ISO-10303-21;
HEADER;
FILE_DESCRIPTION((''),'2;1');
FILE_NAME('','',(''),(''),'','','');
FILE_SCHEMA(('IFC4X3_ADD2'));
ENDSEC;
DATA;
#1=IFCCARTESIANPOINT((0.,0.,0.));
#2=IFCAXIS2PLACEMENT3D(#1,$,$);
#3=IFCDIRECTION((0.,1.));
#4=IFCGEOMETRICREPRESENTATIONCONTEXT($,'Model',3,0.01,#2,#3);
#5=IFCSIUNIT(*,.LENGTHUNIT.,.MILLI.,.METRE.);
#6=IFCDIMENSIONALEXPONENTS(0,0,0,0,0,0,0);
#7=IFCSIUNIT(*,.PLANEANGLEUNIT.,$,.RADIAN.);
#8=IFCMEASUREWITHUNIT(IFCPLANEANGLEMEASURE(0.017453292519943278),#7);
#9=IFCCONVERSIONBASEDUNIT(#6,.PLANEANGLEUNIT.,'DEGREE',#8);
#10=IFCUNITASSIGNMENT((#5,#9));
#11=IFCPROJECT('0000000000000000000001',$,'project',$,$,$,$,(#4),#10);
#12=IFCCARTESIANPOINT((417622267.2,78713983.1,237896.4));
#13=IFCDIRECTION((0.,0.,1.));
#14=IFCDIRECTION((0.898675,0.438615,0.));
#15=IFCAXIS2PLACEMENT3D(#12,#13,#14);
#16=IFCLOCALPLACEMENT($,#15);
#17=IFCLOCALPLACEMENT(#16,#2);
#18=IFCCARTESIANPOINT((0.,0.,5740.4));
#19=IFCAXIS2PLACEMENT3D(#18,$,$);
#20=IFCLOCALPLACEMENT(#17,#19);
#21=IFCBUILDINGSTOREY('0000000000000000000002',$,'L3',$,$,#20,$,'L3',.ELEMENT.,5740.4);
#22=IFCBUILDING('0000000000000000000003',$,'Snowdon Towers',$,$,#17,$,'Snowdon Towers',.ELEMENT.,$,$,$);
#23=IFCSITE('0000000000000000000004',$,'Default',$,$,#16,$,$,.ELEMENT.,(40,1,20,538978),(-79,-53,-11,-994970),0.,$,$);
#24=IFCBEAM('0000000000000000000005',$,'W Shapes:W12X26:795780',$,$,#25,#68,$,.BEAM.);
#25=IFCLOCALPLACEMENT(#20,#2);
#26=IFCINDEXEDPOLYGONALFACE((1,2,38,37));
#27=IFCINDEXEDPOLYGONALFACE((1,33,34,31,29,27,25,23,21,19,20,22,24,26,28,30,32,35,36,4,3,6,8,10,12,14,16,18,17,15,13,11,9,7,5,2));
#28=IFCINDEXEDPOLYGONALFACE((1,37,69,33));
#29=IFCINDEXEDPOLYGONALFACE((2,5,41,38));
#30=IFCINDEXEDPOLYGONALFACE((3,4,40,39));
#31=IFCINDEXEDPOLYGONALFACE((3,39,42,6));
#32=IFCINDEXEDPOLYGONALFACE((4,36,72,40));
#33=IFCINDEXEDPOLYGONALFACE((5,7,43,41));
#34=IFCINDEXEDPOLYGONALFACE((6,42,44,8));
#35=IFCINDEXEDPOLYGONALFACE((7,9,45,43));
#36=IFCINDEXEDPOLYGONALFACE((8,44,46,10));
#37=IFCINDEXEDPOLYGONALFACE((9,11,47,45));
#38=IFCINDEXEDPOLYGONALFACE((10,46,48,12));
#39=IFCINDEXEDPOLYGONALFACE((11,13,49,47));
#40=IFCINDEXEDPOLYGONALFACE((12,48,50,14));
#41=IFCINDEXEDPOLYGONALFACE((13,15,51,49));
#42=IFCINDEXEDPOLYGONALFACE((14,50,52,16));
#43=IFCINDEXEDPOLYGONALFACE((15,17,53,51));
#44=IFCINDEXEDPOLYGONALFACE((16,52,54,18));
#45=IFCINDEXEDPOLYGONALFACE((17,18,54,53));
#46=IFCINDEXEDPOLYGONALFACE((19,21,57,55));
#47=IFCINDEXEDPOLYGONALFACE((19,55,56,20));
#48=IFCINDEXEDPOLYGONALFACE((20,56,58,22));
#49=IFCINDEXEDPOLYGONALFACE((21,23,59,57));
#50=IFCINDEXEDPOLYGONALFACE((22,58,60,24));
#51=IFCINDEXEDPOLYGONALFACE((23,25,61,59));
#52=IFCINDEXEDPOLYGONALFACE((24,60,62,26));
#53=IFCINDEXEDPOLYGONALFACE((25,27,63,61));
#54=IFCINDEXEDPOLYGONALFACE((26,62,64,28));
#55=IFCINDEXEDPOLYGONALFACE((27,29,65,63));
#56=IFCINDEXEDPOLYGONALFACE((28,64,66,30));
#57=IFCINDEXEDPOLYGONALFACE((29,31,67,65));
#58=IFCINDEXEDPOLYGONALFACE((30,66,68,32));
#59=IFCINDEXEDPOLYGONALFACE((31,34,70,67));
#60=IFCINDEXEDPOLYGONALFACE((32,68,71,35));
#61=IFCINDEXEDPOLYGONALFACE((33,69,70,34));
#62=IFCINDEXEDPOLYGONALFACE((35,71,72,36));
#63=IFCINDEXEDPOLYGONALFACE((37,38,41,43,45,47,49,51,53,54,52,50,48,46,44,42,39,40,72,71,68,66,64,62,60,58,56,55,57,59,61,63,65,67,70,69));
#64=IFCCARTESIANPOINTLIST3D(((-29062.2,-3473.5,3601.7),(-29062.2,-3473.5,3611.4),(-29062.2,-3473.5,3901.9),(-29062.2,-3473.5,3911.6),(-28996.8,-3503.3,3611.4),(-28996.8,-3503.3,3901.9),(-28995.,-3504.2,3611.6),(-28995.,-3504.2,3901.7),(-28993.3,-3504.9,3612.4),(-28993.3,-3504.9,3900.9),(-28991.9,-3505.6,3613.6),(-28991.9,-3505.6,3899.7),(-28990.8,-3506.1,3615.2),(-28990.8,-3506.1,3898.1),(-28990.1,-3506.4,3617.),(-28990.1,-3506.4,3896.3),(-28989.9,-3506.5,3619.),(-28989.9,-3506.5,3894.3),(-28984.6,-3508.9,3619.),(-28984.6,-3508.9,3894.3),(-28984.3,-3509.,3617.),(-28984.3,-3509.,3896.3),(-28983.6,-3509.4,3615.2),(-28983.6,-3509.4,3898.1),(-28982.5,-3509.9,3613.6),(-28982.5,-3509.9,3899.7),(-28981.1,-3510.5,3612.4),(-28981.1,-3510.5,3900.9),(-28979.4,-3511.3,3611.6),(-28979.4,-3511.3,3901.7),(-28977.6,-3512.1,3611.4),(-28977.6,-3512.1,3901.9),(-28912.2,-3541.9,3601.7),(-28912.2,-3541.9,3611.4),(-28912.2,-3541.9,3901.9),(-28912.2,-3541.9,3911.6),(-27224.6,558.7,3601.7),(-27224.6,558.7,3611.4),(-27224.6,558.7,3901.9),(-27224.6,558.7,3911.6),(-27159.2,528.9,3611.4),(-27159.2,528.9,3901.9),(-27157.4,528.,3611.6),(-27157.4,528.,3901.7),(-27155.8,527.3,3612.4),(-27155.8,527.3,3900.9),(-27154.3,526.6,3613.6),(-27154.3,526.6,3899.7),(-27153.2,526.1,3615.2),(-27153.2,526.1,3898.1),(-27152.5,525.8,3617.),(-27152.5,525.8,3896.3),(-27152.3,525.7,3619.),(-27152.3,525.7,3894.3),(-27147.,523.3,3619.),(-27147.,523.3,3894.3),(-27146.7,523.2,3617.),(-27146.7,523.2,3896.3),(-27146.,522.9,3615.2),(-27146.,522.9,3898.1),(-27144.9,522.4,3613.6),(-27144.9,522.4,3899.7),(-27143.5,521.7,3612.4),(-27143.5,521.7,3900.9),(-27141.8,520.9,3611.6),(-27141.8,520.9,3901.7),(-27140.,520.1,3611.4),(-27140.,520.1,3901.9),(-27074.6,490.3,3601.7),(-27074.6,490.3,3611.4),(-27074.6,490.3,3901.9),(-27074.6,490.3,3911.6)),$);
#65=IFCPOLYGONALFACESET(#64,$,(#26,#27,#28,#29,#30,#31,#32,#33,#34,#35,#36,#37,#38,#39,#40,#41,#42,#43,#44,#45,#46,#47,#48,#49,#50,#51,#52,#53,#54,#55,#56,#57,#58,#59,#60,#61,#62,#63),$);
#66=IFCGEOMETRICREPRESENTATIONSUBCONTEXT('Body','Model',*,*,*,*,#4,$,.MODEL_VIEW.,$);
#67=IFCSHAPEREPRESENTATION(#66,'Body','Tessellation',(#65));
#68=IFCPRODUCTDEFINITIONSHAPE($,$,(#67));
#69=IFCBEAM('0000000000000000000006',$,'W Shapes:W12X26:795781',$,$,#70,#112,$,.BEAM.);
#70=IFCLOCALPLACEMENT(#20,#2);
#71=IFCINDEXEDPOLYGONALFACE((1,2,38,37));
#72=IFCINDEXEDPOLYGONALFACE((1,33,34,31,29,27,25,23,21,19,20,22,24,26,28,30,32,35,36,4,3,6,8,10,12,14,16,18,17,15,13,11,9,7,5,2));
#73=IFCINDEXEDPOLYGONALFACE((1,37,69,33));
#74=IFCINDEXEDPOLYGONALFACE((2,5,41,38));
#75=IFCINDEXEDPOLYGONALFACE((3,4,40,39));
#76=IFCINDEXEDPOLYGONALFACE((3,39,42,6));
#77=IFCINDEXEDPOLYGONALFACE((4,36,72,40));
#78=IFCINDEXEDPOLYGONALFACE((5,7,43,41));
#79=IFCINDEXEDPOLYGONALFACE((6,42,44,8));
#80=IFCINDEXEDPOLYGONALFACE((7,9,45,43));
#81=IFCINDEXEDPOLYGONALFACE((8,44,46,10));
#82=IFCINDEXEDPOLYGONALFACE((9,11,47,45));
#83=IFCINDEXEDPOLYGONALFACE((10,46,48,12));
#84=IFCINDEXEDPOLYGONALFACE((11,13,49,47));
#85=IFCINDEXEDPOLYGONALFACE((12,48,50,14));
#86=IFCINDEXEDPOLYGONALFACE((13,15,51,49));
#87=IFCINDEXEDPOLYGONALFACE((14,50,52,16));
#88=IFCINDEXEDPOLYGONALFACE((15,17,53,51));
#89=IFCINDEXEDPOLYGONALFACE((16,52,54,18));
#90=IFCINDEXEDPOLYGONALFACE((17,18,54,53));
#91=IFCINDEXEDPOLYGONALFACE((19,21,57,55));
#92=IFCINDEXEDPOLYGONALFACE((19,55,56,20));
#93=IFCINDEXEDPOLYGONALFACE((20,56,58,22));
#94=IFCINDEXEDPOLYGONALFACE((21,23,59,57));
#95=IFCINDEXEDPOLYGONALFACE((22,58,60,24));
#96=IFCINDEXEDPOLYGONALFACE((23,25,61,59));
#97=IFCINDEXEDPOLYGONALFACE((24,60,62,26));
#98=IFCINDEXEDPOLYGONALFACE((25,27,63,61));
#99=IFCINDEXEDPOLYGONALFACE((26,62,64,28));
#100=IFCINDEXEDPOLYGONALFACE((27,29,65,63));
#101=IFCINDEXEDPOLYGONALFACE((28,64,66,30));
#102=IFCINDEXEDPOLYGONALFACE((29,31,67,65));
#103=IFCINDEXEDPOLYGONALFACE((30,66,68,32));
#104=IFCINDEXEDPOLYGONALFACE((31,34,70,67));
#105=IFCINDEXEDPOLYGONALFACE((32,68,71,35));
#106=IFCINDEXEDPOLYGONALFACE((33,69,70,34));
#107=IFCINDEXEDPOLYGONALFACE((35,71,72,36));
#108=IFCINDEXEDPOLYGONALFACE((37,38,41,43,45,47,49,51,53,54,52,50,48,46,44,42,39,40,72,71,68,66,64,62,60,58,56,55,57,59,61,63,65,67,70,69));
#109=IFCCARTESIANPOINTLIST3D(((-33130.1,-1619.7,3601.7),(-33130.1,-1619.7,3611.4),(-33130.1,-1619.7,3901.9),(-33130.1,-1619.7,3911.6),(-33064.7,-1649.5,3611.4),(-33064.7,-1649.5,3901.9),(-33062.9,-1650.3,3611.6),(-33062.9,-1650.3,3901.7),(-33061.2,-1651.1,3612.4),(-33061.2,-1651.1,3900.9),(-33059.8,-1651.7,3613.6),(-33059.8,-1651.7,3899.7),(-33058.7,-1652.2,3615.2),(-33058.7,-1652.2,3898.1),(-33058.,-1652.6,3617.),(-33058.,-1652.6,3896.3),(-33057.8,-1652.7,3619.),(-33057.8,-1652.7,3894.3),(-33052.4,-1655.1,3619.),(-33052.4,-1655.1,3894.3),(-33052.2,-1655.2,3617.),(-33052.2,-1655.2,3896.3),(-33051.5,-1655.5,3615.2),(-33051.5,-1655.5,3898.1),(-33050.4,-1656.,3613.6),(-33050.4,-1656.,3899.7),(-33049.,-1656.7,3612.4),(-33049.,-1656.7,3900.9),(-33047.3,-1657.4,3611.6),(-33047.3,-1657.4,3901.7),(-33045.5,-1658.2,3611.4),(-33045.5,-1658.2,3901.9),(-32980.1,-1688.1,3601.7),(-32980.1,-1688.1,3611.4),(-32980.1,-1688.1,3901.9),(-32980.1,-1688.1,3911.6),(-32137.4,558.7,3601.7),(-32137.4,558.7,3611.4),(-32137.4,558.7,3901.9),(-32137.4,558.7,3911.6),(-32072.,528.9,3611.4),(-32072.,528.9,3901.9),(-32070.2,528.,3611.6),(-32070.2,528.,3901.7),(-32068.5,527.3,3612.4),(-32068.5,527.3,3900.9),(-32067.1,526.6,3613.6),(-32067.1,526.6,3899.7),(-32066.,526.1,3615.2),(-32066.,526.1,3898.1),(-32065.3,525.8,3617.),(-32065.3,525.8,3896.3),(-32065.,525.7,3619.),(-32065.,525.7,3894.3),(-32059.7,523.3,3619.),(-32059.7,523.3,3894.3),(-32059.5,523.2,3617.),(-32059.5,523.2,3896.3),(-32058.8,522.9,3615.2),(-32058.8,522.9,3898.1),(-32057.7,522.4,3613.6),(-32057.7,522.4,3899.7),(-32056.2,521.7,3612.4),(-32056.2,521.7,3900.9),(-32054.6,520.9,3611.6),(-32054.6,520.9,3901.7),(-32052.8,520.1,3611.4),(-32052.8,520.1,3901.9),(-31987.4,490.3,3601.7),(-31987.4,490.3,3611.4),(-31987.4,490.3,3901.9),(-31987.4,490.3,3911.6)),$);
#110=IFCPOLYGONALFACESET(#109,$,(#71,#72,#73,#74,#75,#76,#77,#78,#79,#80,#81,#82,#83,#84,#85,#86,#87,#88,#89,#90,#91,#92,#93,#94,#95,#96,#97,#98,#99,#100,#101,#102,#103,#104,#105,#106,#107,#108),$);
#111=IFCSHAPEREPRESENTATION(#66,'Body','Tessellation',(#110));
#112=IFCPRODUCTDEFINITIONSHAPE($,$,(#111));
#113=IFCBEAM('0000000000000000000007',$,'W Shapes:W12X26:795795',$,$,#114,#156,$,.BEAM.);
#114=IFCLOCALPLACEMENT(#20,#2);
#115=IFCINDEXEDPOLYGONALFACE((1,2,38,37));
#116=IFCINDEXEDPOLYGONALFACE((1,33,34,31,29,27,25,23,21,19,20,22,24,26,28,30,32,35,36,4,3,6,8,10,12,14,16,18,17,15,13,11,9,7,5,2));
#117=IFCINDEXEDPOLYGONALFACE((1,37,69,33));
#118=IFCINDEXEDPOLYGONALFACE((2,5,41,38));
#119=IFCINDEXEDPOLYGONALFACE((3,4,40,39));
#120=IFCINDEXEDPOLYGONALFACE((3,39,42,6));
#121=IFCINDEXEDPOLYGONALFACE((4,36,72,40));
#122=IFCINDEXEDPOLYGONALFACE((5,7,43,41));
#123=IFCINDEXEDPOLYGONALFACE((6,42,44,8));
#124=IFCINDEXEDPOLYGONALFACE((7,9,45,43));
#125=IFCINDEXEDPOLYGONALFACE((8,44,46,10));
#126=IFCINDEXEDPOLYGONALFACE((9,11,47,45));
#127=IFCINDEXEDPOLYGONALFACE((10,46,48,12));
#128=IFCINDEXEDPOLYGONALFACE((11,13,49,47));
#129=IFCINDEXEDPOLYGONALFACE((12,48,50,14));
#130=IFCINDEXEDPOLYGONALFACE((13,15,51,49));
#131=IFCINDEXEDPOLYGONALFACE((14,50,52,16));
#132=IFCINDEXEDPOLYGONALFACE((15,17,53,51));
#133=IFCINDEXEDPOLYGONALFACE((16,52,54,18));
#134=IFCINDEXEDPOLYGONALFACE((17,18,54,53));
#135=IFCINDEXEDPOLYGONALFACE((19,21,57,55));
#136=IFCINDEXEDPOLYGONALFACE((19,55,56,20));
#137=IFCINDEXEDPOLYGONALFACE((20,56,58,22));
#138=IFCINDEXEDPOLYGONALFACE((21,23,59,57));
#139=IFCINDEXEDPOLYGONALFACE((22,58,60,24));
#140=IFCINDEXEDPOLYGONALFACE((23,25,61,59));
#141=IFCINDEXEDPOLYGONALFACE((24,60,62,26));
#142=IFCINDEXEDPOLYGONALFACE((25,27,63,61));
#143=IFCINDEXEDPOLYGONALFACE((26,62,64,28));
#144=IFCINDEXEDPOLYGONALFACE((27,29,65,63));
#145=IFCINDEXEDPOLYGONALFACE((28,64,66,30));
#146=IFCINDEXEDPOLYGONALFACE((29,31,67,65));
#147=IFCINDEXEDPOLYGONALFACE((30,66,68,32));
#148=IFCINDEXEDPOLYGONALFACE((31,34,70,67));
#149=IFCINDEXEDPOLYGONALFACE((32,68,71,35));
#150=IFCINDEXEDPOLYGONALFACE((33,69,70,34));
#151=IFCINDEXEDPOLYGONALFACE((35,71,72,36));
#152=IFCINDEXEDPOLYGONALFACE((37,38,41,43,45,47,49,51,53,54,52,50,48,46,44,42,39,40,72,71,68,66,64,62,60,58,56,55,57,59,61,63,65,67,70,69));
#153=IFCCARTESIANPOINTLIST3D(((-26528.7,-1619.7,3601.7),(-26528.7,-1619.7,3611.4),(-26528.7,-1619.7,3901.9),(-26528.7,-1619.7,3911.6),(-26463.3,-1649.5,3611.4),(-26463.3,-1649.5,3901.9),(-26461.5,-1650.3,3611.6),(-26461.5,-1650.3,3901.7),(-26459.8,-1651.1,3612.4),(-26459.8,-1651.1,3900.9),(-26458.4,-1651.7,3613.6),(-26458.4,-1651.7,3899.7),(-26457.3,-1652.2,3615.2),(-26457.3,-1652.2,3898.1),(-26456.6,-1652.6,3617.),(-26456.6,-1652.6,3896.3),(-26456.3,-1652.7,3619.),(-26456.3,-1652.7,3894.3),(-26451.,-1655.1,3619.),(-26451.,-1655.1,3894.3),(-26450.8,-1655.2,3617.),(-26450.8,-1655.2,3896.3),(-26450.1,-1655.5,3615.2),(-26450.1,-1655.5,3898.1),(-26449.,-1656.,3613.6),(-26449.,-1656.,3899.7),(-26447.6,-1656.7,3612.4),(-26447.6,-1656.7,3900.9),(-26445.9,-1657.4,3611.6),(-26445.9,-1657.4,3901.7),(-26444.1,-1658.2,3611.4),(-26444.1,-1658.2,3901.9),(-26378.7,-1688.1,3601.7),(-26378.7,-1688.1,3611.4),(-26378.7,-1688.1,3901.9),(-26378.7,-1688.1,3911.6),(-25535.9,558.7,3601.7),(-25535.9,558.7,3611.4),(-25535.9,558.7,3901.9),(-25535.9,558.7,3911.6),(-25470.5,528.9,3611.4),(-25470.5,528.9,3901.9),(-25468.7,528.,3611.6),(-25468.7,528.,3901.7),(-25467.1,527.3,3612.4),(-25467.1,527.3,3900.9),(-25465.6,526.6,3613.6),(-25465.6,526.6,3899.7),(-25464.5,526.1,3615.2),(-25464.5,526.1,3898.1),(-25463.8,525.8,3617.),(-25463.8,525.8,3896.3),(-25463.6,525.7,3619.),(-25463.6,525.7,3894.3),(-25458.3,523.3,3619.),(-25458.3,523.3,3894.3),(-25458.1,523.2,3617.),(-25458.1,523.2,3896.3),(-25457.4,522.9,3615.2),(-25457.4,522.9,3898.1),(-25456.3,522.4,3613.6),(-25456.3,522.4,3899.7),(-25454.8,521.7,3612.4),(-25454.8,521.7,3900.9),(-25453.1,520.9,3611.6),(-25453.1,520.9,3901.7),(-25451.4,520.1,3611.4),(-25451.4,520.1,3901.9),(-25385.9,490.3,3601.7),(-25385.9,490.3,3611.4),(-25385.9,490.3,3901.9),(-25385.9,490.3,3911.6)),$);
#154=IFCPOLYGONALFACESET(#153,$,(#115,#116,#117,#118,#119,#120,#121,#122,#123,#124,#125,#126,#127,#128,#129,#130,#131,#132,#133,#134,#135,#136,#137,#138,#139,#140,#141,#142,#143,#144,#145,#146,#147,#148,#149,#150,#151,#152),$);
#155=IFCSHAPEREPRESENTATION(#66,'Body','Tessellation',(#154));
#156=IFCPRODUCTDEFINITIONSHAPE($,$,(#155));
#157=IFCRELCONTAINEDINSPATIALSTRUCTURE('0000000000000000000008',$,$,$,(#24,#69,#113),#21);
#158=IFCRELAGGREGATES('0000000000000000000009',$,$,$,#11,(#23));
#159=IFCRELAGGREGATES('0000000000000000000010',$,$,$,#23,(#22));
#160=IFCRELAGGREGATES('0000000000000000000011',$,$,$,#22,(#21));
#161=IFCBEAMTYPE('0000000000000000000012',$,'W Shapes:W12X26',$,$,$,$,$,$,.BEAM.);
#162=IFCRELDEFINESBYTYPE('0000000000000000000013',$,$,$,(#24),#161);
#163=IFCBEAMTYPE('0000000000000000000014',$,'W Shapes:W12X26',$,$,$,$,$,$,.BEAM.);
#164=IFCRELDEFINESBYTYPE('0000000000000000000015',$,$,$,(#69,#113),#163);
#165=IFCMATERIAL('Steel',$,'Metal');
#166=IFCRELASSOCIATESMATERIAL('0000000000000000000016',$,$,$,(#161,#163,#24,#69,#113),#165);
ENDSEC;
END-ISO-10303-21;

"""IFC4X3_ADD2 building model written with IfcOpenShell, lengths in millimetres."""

from ifc_helpers import new_model, entity, si_unit, converted_unit, direction, frame, frame_2d, origin, place, context, subcontext, project, spatial, polyline, circle_curve, parameter, trimmed, segment, composite_curve, outline, extrude, source, transform, mapped, material, material_profile, profile_set, profile_usage, type_object, type_shapes, element, save


model = new_model("IFC4X3_ADD2")

# Units and contexts
model_context = context("Model", 3, precision=0.01, world=origin(), true_north=direction((0.0, 1.0)))
body_context = subcontext(model_context, "Body", "Model", "MODEL_VIEW")
ifc_project = project(units=[si_unit("LENGTHUNIT", "METRE", prefix="MILLI"), converted_unit("PLANEANGLEUNIT", "DEGREE", entity("IfcPlaneAngleMeasure", 0.017453292519943278), si_unit("PLANEANGLEUNIT", "RADIAN"), dimensions=[0, 0, 0, 0, 0, 0, 0])], contexts=[model_context])

# Site, building, storey
site_placement = place(None, frame((417622267.2, 78713983.1, 237896.4), z_axis=(0.0, 0.0, 1.0), x_axis=(0.898675, 0.438615, 0.0)))
site = spatial("IfcSite", under=ifc_project, at=site_placement, Name="Default", CompositionType="ELEMENT", RefLatitude=(40, 1, 20, 538978), RefLongitude=(-79, -53, -11, -994970), RefElevation=0.0)
building_placement = place(site_placement, origin())
building = spatial("IfcBuilding", under=site, at=building_placement, Name="Snowdon Towers", LongName="Snowdon Towers", CompositionType="ELEMENT")
storey_placement = place(building_placement, frame((0.0, 0.0, 5740.4)))
storey = spatial("IfcBuildingStorey", under=building, at=storey_placement, Name="L3", LongName="L3", CompositionType="ELEMENT", Elevation=5740.4)

# Shared definitions
ifc_material_1 = material(Name="Steel", Category="Metal")

# Beams
ifc_material_profile_1 = material_profile(ifc_material_1, outline(composite_curve([segment(polyline([(-82.4, -145.3), (-82.4, -154.9)]), True, "CONTINUOUS"), segment(polyline([(-82.4, -154.9), (82.4, -154.9)]), True, "CONTINUOUS"), segment(polyline([(82.4, -154.9), (82.4, -145.3)]), True, "CONTINUOUS"), segment(polyline([(82.4, -145.3), (10.5, -145.3)]), True, "CONTINUOUS"), segment(trimmed(circle_curve(frame_2d((10.5, -137.7), x_axis=(1.0, 0.0)), 7.6), [parameter(180.0)], [parameter(270.0)], True, "PARAMETER"), False, "CONTINUOUS"), segment(polyline([(2.9, -137.7), (2.9, 137.7)]), True, "CONTINUOUS"), segment(trimmed(circle_curve(frame_2d((10.5, 137.7), x_axis=(1.0, 0.0)), 7.6), [parameter(90.0)], [parameter(180.0)], True, "PARAMETER"), False, "CONTINUOUS"), segment(polyline([(10.5, 145.3), (82.4, 145.3)]), True, "CONTINUOUS"), segment(polyline([(82.4, 145.3), (82.4, 154.9)]), True, "CONTINUOUS"), segment(polyline([(82.4, 154.9), (-82.4, 154.9)]), True, "CONTINUOUS"), segment(polyline([(-82.4, 154.9), (-82.4, 145.3)]), True, "CONTINUOUS"), segment(polyline([(-82.4, 145.3), (-10.5, 145.3)]), True, "CONTINUOUS"), segment(trimmed(circle_curve(frame_2d((-10.5, 137.7), x_axis=(1.0, 0.0)), 7.6), [parameter(360.0)], [parameter(90.0)], True, "PARAMETER"), False, "CONTINUOUS"), segment(polyline([(-2.9, 137.7), (-2.9, -137.7)]), True, "CONTINUOUS"), segment(trimmed(circle_curve(frame_2d((-10.5, -137.7), x_axis=(1.0, 0.0)), 7.6), [parameter(270.0)], [parameter(360.0)], True, "PARAMETER"), False, "CONTINUOUS"), segment(polyline([(-10.5, -145.3), (-82.4, -145.3)]), True, "CONTINUOUS")], self_intersect=False)), Name="W12X26")
ifc_profile_set_1 = profile_set([ifc_material_profile_1], Name="W12X26")
ifc_profile_usage_1 = profile_usage(ifc_profile_set_1, cardinal=8)
beam_type_1 = type_object("IfcBeamType", Name="W Shapes:W12X26", PredefinedType="BEAM", material=ifc_profile_set_1)
shared_shape_1 = source(origin(), body_context, "Body", "SweptSolid", [
    extrude(outline(composite_curve([segment(polyline([(-82.4, -145.3), (-82.4, -154.9)]), True, "CONTINUOUS"), segment(polyline([(-82.4, -154.9), (82.4, -154.9)]), True, "CONTINUOUS"), segment(polyline([(82.4, -154.9), (82.4, -145.3)]), True, "CONTINUOUS"), segment(polyline([(82.4, -145.3), (10.5, -145.3)]), True, "CONTINUOUS"), segment(trimmed(circle_curve(frame_2d((10.5, -137.7), x_axis=(0.0, -1.0)), 7.6), [parameter(270.0)], [parameter(360.0)], True, "PARAMETER"), False, "CONTINUOUS"), segment(polyline([(2.9, -137.7), (2.9, 137.7)]), True, "CONTINUOUS"), segment(trimmed(circle_curve(frame_2d((10.5, 137.7), x_axis=(-1.0, 0.0)), 7.6), [parameter(270.0)], [parameter(360.0)], True, "PARAMETER"), False, "CONTINUOUS"), segment(polyline([(10.5, 145.3), (82.4, 145.3)]), True, "CONTINUOUS"), segment(polyline([(82.4, 145.3), (82.4, 154.9)]), True, "CONTINUOUS"), segment(polyline([(82.4, 154.9), (-82.4, 154.9)]), True, "CONTINUOUS"), segment(polyline([(-82.4, 154.9), (-82.4, 145.3)]), True, "CONTINUOUS"), segment(polyline([(-82.4, 145.3), (-10.5, 145.3)]), True, "CONTINUOUS"), segment(trimmed(circle_curve(frame_2d((-10.5, 137.7), x_axis=(0.0, 1.0)), 7.6), [parameter(270.0)], [parameter(0.0)], True, "PARAMETER"), False, "CONTINUOUS"), segment(polyline([(-2.9, 137.7), (-2.9, -137.7)]), True, "CONTINUOUS"), segment(trimmed(circle_curve(frame_2d((-10.5, -137.7), x_axis=(1.0, 0.0)), 7.6), [parameter(270.0)], [parameter(0.0)], True, "PARAMETER"), False, "CONTINUOUS"), segment(polyline([(-10.5, -145.3), (-82.4, -145.3)]), True, "CONTINUOUS")], self_intersect=False)), frame((-2298.5, 0.0, 0.0), z_axis=(-1.0, 0.0, 0.0), x_axis=(0.0, -1.0, 0.0)), (0.0, 0.0, -1.0), 4431.2),
])
type_shapes(beam_type_1, [shared_shape_1])
beam_1_placement = place(storey_placement, frame((-28034.0, -1416.1, 3756.7), z_axis=(0.0, 0.0, 1.0), x_axis=(0.414693, 0.909961, 0.0)))
element("IfcBeam", 1, at=beam_1_placement, inside=storey, type_object=beam_type_1, material=ifc_profile_usage_1, Name="W Shapes:W12X26:795780", PredefinedType="BEAM", context=body_context, shape_type="MappedRepresentation", body=[
    mapped(shared_shape_1, transform((0.0, 0.0, 0.0), scale=1.0)),
])
beam_type_2 = type_object("IfcBeamType", Name="W Shapes:W12X26", PredefinedType="BEAM", material=ifc_profile_set_1)
shared_shape_2 = source(origin(), body_context, "Body", "SweptSolid", [
    extrude(outline(composite_curve([segment(polyline([(-82.4, -145.3), (-82.4, -154.9)]), True, "CONTINUOUS"), segment(polyline([(-82.4, -154.9), (82.4, -154.9)]), True, "CONTINUOUS"), segment(polyline([(82.4, -154.9), (82.4, -145.3)]), True, "CONTINUOUS"), segment(polyline([(82.4, -145.3), (10.5, -145.3)]), True, "CONTINUOUS"), segment(trimmed(circle_curve(frame_2d((10.5, -137.7), x_axis=(0.0, -1.0)), 7.6), [parameter(270.0)], [parameter(360.0)], True, "PARAMETER"), False, "CONTINUOUS"), segment(polyline([(2.9, -137.7), (2.9, 137.7)]), True, "CONTINUOUS"), segment(trimmed(circle_curve(frame_2d((10.5, 137.7), x_axis=(-1.0, 0.0)), 7.6), [parameter(270.0)], [parameter(360.0)], True, "PARAMETER"), False, "CONTINUOUS"), segment(polyline([(10.5, 145.3), (82.4, 145.3)]), True, "CONTINUOUS"), segment(polyline([(82.4, 145.3), (82.4, 154.9)]), True, "CONTINUOUS"), segment(polyline([(82.4, 154.9), (-82.4, 154.9)]), True, "CONTINUOUS"), segment(polyline([(-82.4, 154.9), (-82.4, 145.3)]), True, "CONTINUOUS"), segment(polyline([(-82.4, 145.3), (-10.5, 145.3)]), True, "CONTINUOUS"), segment(trimmed(circle_curve(frame_2d((-10.5, 137.7), x_axis=(0.0, 1.0)), 7.6), [parameter(270.0)], [parameter(0.0)], True, "PARAMETER"), False, "CONTINUOUS"), segment(polyline([(-2.9, 137.7), (-2.9, -137.7)]), True, "CONTINUOUS"), segment(trimmed(circle_curve(frame_2d((-10.5, -137.7), x_axis=(1.0, 0.0)), 7.6), [parameter(270.0)], [parameter(0.0)], True, "PARAMETER"), False, "CONTINUOUS"), segment(polyline([(-10.5, -145.3), (-82.4, -145.3)]), True, "CONTINUOUS")], self_intersect=False)), frame((-1279.9, 0.0, 0.0), z_axis=(-1.0, 0.0, 0.0), x_axis=(0.0, -1.0, 0.0)), (0.0, 0.0, -1.0), 2393.9),
])
type_shapes(beam_type_2, [shared_shape_2])
for number, where, z_axis, x_axis, name in (
    (2, (-32524.3, -489.2, 3756.7), (0.0, 0.0, 1.0), (0.414693, 0.909961, 0.0), "W Shapes:W12X26:795781"),
    (3, (-25922.9, -489.2, 3756.7), (0.0, 0.0, 1.0), (0.414693, 0.909961, 0.0), "W Shapes:W12X26:795795"),
):
    element("IfcBeam", number, at=place(storey_placement, frame(where, z_axis=z_axis, x_axis=x_axis)), inside=storey, type_object=beam_type_2, material=ifc_profile_usage_1, Name=name, PredefinedType="BEAM", context=body_context, shape_type="MappedRepresentation", body=[
        mapped(shared_shape_2, transform((0.0, 0.0, 0.0), scale=1.0)),
    ])

save(model, "model.ifc")
